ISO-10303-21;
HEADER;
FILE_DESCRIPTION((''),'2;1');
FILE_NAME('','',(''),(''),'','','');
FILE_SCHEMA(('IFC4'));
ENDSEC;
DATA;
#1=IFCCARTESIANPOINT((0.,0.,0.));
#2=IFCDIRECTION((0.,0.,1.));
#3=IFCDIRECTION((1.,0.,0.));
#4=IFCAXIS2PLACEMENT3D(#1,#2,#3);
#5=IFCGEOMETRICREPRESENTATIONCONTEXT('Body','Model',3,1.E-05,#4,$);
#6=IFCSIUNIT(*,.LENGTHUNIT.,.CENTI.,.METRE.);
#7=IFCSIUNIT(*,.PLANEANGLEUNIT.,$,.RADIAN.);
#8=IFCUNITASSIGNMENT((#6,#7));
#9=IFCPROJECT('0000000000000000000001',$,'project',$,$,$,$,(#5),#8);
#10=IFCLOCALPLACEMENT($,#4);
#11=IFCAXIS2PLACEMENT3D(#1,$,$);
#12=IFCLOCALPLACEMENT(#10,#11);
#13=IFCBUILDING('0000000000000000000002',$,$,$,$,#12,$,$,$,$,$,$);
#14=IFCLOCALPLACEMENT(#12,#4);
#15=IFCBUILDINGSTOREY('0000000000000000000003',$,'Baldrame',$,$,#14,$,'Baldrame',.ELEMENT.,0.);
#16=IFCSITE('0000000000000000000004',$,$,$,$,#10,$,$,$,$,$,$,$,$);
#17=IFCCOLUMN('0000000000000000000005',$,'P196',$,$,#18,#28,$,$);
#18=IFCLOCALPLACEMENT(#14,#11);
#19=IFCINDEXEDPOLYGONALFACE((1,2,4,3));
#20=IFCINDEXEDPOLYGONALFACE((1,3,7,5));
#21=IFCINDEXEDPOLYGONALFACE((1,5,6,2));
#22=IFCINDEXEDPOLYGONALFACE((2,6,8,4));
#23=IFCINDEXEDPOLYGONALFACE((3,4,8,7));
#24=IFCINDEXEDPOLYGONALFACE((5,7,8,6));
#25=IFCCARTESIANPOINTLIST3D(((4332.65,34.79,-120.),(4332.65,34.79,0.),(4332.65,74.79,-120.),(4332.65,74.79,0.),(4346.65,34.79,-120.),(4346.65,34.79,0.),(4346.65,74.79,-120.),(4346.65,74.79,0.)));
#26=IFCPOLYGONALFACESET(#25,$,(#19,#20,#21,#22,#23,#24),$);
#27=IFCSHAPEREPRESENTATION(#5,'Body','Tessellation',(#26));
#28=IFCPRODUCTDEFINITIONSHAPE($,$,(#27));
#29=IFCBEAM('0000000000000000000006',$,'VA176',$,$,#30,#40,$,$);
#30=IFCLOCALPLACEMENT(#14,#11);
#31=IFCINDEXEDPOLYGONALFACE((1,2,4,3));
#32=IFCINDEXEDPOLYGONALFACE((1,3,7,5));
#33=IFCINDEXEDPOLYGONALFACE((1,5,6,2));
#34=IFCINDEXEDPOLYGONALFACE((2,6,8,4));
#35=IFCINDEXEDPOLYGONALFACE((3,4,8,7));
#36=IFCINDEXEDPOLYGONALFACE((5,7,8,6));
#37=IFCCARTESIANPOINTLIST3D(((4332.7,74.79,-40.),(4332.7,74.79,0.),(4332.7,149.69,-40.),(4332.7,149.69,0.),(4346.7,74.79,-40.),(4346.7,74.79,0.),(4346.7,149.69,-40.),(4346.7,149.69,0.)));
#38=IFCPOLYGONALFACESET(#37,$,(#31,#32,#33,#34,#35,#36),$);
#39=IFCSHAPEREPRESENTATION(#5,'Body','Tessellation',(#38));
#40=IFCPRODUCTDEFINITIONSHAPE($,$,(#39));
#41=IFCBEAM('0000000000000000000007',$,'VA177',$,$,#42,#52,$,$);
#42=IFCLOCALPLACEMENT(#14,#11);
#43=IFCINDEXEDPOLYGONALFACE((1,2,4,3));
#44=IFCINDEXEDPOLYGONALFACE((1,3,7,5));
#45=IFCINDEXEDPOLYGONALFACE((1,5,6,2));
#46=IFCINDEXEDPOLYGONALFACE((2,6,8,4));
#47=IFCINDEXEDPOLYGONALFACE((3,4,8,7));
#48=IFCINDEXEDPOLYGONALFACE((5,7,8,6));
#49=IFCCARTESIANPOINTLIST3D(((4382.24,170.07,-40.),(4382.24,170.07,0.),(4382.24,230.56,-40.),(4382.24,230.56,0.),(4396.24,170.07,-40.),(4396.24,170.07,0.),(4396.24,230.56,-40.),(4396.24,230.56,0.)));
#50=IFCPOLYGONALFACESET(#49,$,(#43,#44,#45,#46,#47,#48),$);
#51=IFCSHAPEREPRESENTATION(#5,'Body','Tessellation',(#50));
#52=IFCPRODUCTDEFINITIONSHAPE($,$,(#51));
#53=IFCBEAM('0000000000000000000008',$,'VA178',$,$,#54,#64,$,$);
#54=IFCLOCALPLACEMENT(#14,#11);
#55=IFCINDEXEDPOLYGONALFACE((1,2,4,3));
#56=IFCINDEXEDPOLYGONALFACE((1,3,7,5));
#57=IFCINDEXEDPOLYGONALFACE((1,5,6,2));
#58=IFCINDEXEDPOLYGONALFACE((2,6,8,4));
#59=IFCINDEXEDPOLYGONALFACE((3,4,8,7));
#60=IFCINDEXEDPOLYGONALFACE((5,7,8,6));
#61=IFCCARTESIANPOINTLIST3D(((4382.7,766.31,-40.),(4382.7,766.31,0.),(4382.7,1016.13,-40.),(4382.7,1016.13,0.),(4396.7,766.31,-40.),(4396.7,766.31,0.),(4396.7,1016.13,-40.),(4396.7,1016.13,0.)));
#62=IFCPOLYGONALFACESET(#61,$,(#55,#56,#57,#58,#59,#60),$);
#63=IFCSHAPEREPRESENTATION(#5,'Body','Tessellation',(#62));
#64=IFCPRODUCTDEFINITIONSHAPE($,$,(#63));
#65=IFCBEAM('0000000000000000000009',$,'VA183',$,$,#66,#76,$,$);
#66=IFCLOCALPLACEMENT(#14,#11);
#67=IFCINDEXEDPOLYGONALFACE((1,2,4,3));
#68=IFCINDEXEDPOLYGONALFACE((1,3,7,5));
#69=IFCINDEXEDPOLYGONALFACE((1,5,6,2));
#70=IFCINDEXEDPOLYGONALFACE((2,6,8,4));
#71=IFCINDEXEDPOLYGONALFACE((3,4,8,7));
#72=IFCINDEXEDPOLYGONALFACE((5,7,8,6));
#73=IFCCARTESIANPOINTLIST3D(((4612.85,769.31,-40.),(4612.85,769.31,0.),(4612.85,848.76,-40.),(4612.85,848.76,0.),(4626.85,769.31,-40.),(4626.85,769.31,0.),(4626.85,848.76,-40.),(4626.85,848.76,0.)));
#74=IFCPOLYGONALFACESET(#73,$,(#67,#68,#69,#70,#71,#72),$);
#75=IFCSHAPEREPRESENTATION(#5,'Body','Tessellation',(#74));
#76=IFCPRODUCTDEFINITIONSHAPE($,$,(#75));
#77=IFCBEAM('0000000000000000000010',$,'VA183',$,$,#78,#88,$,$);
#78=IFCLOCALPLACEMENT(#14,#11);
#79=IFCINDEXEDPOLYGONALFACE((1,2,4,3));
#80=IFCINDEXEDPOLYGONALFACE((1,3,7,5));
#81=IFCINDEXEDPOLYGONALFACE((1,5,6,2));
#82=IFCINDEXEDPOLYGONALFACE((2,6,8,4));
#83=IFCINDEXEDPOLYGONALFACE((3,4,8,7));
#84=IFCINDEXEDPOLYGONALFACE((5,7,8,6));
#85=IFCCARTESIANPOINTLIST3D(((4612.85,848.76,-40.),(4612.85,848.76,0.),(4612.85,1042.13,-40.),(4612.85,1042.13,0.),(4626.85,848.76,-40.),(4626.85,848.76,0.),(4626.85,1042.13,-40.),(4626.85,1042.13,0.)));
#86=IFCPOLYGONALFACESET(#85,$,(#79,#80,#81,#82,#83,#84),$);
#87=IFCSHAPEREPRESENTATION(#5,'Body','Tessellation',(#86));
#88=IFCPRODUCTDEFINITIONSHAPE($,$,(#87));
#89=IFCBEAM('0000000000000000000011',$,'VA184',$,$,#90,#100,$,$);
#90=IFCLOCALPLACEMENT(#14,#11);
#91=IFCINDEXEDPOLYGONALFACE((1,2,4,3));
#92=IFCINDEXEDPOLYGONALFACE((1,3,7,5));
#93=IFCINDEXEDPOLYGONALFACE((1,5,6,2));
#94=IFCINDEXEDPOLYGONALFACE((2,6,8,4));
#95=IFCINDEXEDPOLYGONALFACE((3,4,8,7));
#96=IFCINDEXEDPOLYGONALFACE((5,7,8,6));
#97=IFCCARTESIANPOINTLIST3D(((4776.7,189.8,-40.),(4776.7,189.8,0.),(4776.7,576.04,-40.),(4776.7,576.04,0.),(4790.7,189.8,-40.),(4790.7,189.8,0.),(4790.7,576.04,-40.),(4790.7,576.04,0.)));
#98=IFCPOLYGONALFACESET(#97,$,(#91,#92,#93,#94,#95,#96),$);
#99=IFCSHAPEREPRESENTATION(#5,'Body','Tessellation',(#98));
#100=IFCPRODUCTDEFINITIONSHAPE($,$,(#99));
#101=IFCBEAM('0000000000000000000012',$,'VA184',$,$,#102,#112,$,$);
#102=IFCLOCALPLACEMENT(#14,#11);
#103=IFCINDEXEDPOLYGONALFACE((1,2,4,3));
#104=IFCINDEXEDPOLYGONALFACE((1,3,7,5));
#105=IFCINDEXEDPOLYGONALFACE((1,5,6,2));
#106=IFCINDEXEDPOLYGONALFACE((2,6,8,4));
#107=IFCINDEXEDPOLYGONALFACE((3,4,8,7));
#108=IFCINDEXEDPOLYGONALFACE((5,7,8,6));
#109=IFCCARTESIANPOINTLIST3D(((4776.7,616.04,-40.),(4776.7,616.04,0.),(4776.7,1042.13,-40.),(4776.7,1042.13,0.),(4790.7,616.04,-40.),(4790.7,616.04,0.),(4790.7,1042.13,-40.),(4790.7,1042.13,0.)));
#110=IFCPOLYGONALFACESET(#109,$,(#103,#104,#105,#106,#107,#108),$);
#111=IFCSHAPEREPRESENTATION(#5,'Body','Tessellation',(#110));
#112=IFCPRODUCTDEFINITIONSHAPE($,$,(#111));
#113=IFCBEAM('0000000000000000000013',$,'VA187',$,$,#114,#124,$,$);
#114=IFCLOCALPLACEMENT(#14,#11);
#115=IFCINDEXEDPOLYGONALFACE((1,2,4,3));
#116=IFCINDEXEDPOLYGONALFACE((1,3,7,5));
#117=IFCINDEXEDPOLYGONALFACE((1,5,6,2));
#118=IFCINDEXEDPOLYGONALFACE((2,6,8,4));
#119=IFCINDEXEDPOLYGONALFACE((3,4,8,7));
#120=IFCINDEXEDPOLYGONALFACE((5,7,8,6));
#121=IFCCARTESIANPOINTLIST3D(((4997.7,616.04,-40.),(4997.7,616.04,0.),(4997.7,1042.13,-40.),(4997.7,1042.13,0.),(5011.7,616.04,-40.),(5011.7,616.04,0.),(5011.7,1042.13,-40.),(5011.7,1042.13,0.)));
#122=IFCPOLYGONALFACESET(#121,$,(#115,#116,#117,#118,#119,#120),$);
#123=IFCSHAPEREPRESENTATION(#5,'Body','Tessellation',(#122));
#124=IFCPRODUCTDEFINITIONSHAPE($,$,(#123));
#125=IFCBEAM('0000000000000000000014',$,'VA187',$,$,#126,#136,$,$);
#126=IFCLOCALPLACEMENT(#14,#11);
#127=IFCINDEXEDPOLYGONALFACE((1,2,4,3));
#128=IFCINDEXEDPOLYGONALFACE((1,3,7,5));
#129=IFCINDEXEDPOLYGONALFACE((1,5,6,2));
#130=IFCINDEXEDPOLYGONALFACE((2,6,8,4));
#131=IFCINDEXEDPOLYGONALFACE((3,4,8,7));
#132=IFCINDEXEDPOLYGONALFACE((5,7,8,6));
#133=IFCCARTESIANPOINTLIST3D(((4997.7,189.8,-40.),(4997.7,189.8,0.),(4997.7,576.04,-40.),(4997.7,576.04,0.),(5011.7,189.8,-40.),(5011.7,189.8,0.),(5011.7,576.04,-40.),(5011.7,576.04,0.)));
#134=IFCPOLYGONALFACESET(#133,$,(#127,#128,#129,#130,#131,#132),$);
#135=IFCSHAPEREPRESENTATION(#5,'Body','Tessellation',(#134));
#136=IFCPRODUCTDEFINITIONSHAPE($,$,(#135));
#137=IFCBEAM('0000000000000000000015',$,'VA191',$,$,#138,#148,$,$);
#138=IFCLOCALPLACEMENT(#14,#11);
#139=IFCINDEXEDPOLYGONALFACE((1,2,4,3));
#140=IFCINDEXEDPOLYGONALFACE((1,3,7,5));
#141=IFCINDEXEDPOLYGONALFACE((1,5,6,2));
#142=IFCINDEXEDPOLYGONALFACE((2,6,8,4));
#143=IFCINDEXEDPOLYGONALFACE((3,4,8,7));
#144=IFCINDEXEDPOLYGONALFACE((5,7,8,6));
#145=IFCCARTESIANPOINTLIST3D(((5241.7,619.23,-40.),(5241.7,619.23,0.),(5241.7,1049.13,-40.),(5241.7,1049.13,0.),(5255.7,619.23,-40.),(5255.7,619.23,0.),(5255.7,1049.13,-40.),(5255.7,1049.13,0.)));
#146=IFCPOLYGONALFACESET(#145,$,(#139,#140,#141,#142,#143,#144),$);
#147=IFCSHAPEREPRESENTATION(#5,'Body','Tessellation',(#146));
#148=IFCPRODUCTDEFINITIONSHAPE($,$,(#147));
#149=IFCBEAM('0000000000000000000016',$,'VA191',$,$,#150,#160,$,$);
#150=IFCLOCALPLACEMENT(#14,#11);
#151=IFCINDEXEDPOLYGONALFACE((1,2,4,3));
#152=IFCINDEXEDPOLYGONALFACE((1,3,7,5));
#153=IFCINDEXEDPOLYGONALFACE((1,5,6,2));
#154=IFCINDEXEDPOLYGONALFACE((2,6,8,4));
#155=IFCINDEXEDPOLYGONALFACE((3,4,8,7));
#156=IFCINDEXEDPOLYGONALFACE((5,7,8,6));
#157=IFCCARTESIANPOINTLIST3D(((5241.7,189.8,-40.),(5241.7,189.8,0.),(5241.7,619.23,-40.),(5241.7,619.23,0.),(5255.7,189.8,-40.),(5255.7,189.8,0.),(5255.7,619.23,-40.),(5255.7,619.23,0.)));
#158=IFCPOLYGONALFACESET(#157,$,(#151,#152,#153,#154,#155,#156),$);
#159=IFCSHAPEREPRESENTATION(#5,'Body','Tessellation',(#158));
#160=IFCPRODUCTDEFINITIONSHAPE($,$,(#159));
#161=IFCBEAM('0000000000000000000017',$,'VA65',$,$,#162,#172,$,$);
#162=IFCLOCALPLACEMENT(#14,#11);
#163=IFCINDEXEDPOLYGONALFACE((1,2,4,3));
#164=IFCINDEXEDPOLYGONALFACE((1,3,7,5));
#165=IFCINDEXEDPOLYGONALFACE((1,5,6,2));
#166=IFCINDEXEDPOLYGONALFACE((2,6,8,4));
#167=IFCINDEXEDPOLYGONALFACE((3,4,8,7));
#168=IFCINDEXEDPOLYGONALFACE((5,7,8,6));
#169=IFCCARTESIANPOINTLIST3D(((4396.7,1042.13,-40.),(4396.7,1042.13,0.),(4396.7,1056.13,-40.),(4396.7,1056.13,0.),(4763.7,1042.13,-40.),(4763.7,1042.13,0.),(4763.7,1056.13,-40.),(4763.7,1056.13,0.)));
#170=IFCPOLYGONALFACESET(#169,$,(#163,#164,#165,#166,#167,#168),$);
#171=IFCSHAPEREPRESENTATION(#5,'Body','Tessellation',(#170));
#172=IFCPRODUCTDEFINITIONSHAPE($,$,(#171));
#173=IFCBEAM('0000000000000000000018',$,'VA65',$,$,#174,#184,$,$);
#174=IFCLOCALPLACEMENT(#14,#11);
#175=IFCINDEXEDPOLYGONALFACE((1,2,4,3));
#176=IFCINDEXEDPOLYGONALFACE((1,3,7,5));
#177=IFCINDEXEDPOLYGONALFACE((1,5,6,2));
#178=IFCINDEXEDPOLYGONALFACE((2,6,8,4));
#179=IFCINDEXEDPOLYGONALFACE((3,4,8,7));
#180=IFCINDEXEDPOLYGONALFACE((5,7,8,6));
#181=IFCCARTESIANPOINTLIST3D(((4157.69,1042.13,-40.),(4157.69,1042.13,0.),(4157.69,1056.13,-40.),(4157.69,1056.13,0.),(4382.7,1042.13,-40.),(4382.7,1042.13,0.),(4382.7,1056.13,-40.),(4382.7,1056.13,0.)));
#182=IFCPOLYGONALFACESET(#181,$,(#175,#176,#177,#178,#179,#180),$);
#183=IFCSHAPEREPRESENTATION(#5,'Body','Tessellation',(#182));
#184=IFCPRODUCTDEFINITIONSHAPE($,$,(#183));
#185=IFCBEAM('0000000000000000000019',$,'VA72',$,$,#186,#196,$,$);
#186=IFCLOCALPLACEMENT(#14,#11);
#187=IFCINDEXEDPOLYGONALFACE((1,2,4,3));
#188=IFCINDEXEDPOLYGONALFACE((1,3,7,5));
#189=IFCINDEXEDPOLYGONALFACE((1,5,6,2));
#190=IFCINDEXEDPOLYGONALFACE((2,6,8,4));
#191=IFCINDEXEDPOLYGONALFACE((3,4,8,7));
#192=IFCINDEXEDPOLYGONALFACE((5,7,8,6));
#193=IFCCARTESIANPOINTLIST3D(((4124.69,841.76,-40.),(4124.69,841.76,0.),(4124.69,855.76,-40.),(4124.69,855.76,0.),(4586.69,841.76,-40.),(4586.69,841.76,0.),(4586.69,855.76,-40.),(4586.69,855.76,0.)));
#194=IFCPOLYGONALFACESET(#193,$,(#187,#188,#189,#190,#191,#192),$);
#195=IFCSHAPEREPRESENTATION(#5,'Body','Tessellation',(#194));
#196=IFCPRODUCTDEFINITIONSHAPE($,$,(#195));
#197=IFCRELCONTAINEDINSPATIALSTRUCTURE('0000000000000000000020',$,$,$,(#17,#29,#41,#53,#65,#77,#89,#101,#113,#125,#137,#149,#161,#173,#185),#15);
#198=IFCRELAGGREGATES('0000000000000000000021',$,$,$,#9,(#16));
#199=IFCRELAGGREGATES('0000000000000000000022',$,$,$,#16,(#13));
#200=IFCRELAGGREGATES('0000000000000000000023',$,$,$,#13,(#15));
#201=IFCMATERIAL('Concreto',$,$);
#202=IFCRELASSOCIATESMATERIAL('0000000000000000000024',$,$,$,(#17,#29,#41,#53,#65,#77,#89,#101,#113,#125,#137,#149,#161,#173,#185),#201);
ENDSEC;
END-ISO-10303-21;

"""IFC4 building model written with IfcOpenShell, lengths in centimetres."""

from ifc_helpers import new_model, si_unit, frame, origin, origin_with_axes, origin_2d_with_axis, place, context, project, spatial, rectangle, extrude, material, element, save


model = new_model("IFC4")

# Units and contexts
model_context = context("Model", 3, precision=1e-05, world=origin_with_axes(), identifier="Body")
ifc_project = project(units=[si_unit("LENGTHUNIT", "METRE", prefix="CENTI"), si_unit("PLANEANGLEUNIT", "RADIAN")], contexts=[model_context])

# Site, building, storey
site_placement = place(None, origin_with_axes())
site = spatial("IfcSite", under=ifc_project, at=site_placement)
building_placement = place(site_placement, origin())
building = spatial("IfcBuilding", under=site, at=building_placement)
storey_placement = place(building_placement, origin_with_axes())
storey = spatial("IfcBuildingStorey", under=building, at=storey_placement, Name="Baldrame", LongName="Baldrame", CompositionType="ELEMENT", Elevation=0.0)

# Shared definitions
ifc_material = material(Name="Concreto")

# Column
column_1_placement = place(storey_placement, frame((4339.65, 54.79, 0.0), z_axis=(0.0, 0.0, 1.0), x_axis=(1.0, 0.0, 0.0)))
element("IfcColumn", 1, at=column_1_placement, inside=storey, material=ifc_material, Name="P196", context=model_context, shape_type="SolidModel", body=[
    extrude(rectangle(XDim=14.0, YDim=40.0, at=origin_2d_with_axis()), frame((0.0, 0.0, -120.0), z_axis=(0.0, 0.0, 1.0), x_axis=(-1.0, 0.0, 0.0)), (0.0, 0.0, 1.0), 120.0),
])

# Beams
beam_1_placement = place(storey_placement, frame((4339.7, 112.24, 0.0), z_axis=(0.0, 0.0, 1.0), x_axis=(1.0, 0.0, 0.0)))
element("IfcBeam", 2, at=beam_1_placement, inside=storey, material=ifc_material, Name="VA176", context=model_context, shape_type="SolidModel", body=[
    extrude(rectangle(XDim=14.0, YDim=40.0, at=origin_2d_with_axis()), frame((0.0, -37.45, -20.0), z_axis=(0.0, 1.0, 0.0), x_axis=(1.0, 0.0, 0.0)), (0.0, 0.0, 1.0), 74.9),
])
beam_2_placement = place(storey_placement, frame((4389.24, 200.31, 0.0), z_axis=(0.0, 0.0, 1.0), x_axis=(1.0, 0.0, 0.0)))
element("IfcBeam", 3, at=beam_2_placement, inside=storey, material=ifc_material, Name="VA177", context=model_context, shape_type="SolidModel", body=[
    extrude(rectangle(XDim=14.0, YDim=40.0, at=origin_2d_with_axis()), frame((0.0, -30.25, -20.0), z_axis=(0.0, 1.0, 0.0), x_axis=(1.0, 0.0, 0.0)), (0.0, 0.0, 1.0), 60.49),
])
beam_3_placement = place(storey_placement, frame((4389.7, 891.22, 0.0), z_axis=(0.0, 0.0, 1.0), x_axis=(1.0, 0.0, 0.0)))
element("IfcBeam", 4, at=beam_3_placement, inside=storey, material=ifc_material, Name="VA178", context=model_context, shape_type="SolidModel", body=[
    extrude(rectangle(XDim=14.0, YDim=40.0, at=origin_2d_with_axis()), frame((0.0, -124.91, -20.0), z_axis=(0.0, 1.0, 0.0), x_axis=(1.0, 0.0, 0.0)), (0.0, 0.0, 1.0), 249.82),
])
beam_4_placement = place(storey_placement, frame((4619.85, 809.03, 0.0), z_axis=(0.0, 0.0, 1.0), x_axis=(1.0, 0.0, 0.0)))
element("IfcBeam", 5, at=beam_4_placement, inside=storey, material=ifc_material, Name="VA183", context=model_context, shape_type="SolidModel", body=[
    extrude(rectangle(XDim=14.0, YDim=40.0, at=origin_2d_with_axis()), frame((0.0, -39.73, -20.0), z_axis=(0.0, 1.0, 0.0), x_axis=(1.0, 0.0, 0.0)), (0.0, 0.0, 1.0), 79.45),
])
beam_5_placement = place(storey_placement, frame((4619.85, 945.45, 0.0), z_axis=(0.0, 0.0, 1.0), x_axis=(1.0, 0.0, 0.0)))
element("IfcBeam", 6, at=beam_5_placement, inside=storey, material=ifc_material, Name="VA183", context=model_context, shape_type="SolidModel", body=[
    extrude(rectangle(XDim=14.0, YDim=40.0, at=origin_2d_with_axis()), frame((0.0, -96.69, -20.0), z_axis=(0.0, 1.0, 0.0), x_axis=(1.0, 0.0, 0.0)), (0.0, 0.0, 1.0), 193.37),
])
beam_6_placement = place(storey_placement, frame((4783.7, 382.92, 0.0), z_axis=(0.0, 0.0, 1.0), x_axis=(1.0, 0.0, 0.0)))
element("IfcBeam", 7, at=beam_6_placement, inside=storey, material=ifc_material, Name="VA184", context=model_context, shape_type="SolidModel", body=[
    extrude(rectangle(XDim=14.0, YDim=40.0, at=origin_2d_with_axis()), frame((0.0, -193.12, -20.0), z_axis=(0.0, 1.0, 0.0), x_axis=(1.0, 0.0, 0.0)), (0.0, 0.0, 1.0), 386.24),
])
for number, where, z_axis, x_axis, name in (
    (8, (4783.7, 829.09, 0.0), (0.0, 0.0, 1.0), (1.0, 0.0, 0.0), "VA184"),
    (9, (5004.7, 829.09, 0.0), (0.0, 0.0, 1.0), (1.0, 0.0, 0.0), "VA187"),
):
    element("IfcBeam", number, at=place(storey_placement, frame(where, z_axis=z_axis, x_axis=x_axis)), inside=storey, material=ifc_material, Name=name, context=model_context, shape_type="SolidModel", body=[
        extrude(rectangle(XDim=14.0, YDim=40.0, at=origin_2d_with_axis()), frame((0.0, -213.04, -20.0), z_axis=(0.0, 1.0, 0.0), x_axis=(1.0, 0.0, 0.0)), (0.0, 0.0, 1.0), 426.09),
    ])
beam_7_placement = place(storey_placement, frame((5004.7, 382.92, 0.0), z_axis=(0.0, 0.0, 1.0), x_axis=(1.0, 0.0, 0.0)))
element("IfcBeam", 10, at=beam_7_placement, inside=storey, material=ifc_material, Name="VA187", context=model_context, shape_type="SolidModel", body=[
    extrude(rectangle(XDim=14.0, YDim=40.0, at=origin_2d_with_axis()), frame((0.0, -193.12, -20.0), z_axis=(0.0, 1.0, 0.0), x_axis=(1.0, 0.0, 0.0)), (0.0, 0.0, 1.0), 386.24),
])
beam_8_placement = place(storey_placement, frame((5248.7, 834.18, 0.0), z_axis=(0.0, 0.0, 1.0), x_axis=(1.0, 0.0, 0.0)))
element("IfcBeam", 11, at=beam_8_placement, inside=storey, material=ifc_material, Name="VA191", context=model_context, shape_type="SolidModel", body=[
    extrude(rectangle(XDim=14.0, YDim=40.0, at=origin_2d_with_axis()), frame((0.0, -214.95, -20.0), z_axis=(0.0, 1.0, 0.0), x_axis=(1.0, 0.0, 0.0)), (0.0, 0.0, 1.0), 429.9),
])
beam_9_placement = place(storey_placement, frame((5248.7, 404.51, 0.0), z_axis=(0.0, 0.0, 1.0), x_axis=(1.0, 0.0, 0.0)))
element("IfcBeam", 12, at=beam_9_placement, inside=storey, material=ifc_material, Name="VA191", context=model_context, shape_type="SolidModel", body=[
    extrude(rectangle(XDim=14.0, YDim=40.0, at=origin_2d_with_axis()), frame((0.0, -214.72, -20.0), z_axis=(0.0, 1.0, 0.0), x_axis=(1.0, 0.0, 0.0)), (0.0, 0.0, 1.0), 429.43),
])
beam_10_placement = place(storey_placement, frame((4580.2, 1049.13, 0.0), z_axis=(0.0, 0.0, 1.0), x_axis=(1.0, 0.0, 0.0)))
element("IfcBeam", 13, at=beam_10_placement, inside=storey, material=ifc_material, Name="VA65", context=model_context, shape_type="SolidModel", body=[
    extrude(rectangle(XDim=14.0, YDim=40.0, at=origin_2d_with_axis()), frame((-183.5, 0.0, -20.0), z_axis=(1.0, 0.0, 0.0), x_axis=(0.0, 1.0, 0.0)), (0.0, 0.0, 1.0), 367.0),
])
beam_11_placement = place(storey_placement, frame((4270.19, 1049.13, 0.0), z_axis=(0.0, 0.0, 1.0), x_axis=(1.0, 0.0, 0.0)))
element("IfcBeam", 14, at=beam_11_placement, inside=storey, material=ifc_material, Name="VA65", context=model_context, shape_type="SolidModel", body=[
    extrude(rectangle(XDim=14.0, YDim=40.0, at=origin_2d_with_axis()), frame((-112.5, 0.0, -20.0), z_axis=(1.0, 0.0, 0.0), x_axis=(0.0, 1.0, 0.0)), (0.0, 0.0, 1.0), 225.01),
])
beam_12_placement = place(storey_placement, frame((4355.69, 848.76, 0.0), z_axis=(0.0, 0.0, 1.0), x_axis=(1.0, 0.0, 0.0)))
element("IfcBeam", 15, at=beam_12_placement, inside=storey, material=ifc_material, Name="VA72", context=model_context, shape_type="SolidModel", body=[
    extrude(rectangle(XDim=14.0, YDim=40.0, at=origin_2d_with_axis()), frame((-231.0, 0.0, -20.0), z_axis=(1.0, 0.0, 0.0), x_axis=(0.0, 1.0, 0.0)), (0.0, 0.0, 1.0), 462.0),
])

save(model, "model.ifc")
